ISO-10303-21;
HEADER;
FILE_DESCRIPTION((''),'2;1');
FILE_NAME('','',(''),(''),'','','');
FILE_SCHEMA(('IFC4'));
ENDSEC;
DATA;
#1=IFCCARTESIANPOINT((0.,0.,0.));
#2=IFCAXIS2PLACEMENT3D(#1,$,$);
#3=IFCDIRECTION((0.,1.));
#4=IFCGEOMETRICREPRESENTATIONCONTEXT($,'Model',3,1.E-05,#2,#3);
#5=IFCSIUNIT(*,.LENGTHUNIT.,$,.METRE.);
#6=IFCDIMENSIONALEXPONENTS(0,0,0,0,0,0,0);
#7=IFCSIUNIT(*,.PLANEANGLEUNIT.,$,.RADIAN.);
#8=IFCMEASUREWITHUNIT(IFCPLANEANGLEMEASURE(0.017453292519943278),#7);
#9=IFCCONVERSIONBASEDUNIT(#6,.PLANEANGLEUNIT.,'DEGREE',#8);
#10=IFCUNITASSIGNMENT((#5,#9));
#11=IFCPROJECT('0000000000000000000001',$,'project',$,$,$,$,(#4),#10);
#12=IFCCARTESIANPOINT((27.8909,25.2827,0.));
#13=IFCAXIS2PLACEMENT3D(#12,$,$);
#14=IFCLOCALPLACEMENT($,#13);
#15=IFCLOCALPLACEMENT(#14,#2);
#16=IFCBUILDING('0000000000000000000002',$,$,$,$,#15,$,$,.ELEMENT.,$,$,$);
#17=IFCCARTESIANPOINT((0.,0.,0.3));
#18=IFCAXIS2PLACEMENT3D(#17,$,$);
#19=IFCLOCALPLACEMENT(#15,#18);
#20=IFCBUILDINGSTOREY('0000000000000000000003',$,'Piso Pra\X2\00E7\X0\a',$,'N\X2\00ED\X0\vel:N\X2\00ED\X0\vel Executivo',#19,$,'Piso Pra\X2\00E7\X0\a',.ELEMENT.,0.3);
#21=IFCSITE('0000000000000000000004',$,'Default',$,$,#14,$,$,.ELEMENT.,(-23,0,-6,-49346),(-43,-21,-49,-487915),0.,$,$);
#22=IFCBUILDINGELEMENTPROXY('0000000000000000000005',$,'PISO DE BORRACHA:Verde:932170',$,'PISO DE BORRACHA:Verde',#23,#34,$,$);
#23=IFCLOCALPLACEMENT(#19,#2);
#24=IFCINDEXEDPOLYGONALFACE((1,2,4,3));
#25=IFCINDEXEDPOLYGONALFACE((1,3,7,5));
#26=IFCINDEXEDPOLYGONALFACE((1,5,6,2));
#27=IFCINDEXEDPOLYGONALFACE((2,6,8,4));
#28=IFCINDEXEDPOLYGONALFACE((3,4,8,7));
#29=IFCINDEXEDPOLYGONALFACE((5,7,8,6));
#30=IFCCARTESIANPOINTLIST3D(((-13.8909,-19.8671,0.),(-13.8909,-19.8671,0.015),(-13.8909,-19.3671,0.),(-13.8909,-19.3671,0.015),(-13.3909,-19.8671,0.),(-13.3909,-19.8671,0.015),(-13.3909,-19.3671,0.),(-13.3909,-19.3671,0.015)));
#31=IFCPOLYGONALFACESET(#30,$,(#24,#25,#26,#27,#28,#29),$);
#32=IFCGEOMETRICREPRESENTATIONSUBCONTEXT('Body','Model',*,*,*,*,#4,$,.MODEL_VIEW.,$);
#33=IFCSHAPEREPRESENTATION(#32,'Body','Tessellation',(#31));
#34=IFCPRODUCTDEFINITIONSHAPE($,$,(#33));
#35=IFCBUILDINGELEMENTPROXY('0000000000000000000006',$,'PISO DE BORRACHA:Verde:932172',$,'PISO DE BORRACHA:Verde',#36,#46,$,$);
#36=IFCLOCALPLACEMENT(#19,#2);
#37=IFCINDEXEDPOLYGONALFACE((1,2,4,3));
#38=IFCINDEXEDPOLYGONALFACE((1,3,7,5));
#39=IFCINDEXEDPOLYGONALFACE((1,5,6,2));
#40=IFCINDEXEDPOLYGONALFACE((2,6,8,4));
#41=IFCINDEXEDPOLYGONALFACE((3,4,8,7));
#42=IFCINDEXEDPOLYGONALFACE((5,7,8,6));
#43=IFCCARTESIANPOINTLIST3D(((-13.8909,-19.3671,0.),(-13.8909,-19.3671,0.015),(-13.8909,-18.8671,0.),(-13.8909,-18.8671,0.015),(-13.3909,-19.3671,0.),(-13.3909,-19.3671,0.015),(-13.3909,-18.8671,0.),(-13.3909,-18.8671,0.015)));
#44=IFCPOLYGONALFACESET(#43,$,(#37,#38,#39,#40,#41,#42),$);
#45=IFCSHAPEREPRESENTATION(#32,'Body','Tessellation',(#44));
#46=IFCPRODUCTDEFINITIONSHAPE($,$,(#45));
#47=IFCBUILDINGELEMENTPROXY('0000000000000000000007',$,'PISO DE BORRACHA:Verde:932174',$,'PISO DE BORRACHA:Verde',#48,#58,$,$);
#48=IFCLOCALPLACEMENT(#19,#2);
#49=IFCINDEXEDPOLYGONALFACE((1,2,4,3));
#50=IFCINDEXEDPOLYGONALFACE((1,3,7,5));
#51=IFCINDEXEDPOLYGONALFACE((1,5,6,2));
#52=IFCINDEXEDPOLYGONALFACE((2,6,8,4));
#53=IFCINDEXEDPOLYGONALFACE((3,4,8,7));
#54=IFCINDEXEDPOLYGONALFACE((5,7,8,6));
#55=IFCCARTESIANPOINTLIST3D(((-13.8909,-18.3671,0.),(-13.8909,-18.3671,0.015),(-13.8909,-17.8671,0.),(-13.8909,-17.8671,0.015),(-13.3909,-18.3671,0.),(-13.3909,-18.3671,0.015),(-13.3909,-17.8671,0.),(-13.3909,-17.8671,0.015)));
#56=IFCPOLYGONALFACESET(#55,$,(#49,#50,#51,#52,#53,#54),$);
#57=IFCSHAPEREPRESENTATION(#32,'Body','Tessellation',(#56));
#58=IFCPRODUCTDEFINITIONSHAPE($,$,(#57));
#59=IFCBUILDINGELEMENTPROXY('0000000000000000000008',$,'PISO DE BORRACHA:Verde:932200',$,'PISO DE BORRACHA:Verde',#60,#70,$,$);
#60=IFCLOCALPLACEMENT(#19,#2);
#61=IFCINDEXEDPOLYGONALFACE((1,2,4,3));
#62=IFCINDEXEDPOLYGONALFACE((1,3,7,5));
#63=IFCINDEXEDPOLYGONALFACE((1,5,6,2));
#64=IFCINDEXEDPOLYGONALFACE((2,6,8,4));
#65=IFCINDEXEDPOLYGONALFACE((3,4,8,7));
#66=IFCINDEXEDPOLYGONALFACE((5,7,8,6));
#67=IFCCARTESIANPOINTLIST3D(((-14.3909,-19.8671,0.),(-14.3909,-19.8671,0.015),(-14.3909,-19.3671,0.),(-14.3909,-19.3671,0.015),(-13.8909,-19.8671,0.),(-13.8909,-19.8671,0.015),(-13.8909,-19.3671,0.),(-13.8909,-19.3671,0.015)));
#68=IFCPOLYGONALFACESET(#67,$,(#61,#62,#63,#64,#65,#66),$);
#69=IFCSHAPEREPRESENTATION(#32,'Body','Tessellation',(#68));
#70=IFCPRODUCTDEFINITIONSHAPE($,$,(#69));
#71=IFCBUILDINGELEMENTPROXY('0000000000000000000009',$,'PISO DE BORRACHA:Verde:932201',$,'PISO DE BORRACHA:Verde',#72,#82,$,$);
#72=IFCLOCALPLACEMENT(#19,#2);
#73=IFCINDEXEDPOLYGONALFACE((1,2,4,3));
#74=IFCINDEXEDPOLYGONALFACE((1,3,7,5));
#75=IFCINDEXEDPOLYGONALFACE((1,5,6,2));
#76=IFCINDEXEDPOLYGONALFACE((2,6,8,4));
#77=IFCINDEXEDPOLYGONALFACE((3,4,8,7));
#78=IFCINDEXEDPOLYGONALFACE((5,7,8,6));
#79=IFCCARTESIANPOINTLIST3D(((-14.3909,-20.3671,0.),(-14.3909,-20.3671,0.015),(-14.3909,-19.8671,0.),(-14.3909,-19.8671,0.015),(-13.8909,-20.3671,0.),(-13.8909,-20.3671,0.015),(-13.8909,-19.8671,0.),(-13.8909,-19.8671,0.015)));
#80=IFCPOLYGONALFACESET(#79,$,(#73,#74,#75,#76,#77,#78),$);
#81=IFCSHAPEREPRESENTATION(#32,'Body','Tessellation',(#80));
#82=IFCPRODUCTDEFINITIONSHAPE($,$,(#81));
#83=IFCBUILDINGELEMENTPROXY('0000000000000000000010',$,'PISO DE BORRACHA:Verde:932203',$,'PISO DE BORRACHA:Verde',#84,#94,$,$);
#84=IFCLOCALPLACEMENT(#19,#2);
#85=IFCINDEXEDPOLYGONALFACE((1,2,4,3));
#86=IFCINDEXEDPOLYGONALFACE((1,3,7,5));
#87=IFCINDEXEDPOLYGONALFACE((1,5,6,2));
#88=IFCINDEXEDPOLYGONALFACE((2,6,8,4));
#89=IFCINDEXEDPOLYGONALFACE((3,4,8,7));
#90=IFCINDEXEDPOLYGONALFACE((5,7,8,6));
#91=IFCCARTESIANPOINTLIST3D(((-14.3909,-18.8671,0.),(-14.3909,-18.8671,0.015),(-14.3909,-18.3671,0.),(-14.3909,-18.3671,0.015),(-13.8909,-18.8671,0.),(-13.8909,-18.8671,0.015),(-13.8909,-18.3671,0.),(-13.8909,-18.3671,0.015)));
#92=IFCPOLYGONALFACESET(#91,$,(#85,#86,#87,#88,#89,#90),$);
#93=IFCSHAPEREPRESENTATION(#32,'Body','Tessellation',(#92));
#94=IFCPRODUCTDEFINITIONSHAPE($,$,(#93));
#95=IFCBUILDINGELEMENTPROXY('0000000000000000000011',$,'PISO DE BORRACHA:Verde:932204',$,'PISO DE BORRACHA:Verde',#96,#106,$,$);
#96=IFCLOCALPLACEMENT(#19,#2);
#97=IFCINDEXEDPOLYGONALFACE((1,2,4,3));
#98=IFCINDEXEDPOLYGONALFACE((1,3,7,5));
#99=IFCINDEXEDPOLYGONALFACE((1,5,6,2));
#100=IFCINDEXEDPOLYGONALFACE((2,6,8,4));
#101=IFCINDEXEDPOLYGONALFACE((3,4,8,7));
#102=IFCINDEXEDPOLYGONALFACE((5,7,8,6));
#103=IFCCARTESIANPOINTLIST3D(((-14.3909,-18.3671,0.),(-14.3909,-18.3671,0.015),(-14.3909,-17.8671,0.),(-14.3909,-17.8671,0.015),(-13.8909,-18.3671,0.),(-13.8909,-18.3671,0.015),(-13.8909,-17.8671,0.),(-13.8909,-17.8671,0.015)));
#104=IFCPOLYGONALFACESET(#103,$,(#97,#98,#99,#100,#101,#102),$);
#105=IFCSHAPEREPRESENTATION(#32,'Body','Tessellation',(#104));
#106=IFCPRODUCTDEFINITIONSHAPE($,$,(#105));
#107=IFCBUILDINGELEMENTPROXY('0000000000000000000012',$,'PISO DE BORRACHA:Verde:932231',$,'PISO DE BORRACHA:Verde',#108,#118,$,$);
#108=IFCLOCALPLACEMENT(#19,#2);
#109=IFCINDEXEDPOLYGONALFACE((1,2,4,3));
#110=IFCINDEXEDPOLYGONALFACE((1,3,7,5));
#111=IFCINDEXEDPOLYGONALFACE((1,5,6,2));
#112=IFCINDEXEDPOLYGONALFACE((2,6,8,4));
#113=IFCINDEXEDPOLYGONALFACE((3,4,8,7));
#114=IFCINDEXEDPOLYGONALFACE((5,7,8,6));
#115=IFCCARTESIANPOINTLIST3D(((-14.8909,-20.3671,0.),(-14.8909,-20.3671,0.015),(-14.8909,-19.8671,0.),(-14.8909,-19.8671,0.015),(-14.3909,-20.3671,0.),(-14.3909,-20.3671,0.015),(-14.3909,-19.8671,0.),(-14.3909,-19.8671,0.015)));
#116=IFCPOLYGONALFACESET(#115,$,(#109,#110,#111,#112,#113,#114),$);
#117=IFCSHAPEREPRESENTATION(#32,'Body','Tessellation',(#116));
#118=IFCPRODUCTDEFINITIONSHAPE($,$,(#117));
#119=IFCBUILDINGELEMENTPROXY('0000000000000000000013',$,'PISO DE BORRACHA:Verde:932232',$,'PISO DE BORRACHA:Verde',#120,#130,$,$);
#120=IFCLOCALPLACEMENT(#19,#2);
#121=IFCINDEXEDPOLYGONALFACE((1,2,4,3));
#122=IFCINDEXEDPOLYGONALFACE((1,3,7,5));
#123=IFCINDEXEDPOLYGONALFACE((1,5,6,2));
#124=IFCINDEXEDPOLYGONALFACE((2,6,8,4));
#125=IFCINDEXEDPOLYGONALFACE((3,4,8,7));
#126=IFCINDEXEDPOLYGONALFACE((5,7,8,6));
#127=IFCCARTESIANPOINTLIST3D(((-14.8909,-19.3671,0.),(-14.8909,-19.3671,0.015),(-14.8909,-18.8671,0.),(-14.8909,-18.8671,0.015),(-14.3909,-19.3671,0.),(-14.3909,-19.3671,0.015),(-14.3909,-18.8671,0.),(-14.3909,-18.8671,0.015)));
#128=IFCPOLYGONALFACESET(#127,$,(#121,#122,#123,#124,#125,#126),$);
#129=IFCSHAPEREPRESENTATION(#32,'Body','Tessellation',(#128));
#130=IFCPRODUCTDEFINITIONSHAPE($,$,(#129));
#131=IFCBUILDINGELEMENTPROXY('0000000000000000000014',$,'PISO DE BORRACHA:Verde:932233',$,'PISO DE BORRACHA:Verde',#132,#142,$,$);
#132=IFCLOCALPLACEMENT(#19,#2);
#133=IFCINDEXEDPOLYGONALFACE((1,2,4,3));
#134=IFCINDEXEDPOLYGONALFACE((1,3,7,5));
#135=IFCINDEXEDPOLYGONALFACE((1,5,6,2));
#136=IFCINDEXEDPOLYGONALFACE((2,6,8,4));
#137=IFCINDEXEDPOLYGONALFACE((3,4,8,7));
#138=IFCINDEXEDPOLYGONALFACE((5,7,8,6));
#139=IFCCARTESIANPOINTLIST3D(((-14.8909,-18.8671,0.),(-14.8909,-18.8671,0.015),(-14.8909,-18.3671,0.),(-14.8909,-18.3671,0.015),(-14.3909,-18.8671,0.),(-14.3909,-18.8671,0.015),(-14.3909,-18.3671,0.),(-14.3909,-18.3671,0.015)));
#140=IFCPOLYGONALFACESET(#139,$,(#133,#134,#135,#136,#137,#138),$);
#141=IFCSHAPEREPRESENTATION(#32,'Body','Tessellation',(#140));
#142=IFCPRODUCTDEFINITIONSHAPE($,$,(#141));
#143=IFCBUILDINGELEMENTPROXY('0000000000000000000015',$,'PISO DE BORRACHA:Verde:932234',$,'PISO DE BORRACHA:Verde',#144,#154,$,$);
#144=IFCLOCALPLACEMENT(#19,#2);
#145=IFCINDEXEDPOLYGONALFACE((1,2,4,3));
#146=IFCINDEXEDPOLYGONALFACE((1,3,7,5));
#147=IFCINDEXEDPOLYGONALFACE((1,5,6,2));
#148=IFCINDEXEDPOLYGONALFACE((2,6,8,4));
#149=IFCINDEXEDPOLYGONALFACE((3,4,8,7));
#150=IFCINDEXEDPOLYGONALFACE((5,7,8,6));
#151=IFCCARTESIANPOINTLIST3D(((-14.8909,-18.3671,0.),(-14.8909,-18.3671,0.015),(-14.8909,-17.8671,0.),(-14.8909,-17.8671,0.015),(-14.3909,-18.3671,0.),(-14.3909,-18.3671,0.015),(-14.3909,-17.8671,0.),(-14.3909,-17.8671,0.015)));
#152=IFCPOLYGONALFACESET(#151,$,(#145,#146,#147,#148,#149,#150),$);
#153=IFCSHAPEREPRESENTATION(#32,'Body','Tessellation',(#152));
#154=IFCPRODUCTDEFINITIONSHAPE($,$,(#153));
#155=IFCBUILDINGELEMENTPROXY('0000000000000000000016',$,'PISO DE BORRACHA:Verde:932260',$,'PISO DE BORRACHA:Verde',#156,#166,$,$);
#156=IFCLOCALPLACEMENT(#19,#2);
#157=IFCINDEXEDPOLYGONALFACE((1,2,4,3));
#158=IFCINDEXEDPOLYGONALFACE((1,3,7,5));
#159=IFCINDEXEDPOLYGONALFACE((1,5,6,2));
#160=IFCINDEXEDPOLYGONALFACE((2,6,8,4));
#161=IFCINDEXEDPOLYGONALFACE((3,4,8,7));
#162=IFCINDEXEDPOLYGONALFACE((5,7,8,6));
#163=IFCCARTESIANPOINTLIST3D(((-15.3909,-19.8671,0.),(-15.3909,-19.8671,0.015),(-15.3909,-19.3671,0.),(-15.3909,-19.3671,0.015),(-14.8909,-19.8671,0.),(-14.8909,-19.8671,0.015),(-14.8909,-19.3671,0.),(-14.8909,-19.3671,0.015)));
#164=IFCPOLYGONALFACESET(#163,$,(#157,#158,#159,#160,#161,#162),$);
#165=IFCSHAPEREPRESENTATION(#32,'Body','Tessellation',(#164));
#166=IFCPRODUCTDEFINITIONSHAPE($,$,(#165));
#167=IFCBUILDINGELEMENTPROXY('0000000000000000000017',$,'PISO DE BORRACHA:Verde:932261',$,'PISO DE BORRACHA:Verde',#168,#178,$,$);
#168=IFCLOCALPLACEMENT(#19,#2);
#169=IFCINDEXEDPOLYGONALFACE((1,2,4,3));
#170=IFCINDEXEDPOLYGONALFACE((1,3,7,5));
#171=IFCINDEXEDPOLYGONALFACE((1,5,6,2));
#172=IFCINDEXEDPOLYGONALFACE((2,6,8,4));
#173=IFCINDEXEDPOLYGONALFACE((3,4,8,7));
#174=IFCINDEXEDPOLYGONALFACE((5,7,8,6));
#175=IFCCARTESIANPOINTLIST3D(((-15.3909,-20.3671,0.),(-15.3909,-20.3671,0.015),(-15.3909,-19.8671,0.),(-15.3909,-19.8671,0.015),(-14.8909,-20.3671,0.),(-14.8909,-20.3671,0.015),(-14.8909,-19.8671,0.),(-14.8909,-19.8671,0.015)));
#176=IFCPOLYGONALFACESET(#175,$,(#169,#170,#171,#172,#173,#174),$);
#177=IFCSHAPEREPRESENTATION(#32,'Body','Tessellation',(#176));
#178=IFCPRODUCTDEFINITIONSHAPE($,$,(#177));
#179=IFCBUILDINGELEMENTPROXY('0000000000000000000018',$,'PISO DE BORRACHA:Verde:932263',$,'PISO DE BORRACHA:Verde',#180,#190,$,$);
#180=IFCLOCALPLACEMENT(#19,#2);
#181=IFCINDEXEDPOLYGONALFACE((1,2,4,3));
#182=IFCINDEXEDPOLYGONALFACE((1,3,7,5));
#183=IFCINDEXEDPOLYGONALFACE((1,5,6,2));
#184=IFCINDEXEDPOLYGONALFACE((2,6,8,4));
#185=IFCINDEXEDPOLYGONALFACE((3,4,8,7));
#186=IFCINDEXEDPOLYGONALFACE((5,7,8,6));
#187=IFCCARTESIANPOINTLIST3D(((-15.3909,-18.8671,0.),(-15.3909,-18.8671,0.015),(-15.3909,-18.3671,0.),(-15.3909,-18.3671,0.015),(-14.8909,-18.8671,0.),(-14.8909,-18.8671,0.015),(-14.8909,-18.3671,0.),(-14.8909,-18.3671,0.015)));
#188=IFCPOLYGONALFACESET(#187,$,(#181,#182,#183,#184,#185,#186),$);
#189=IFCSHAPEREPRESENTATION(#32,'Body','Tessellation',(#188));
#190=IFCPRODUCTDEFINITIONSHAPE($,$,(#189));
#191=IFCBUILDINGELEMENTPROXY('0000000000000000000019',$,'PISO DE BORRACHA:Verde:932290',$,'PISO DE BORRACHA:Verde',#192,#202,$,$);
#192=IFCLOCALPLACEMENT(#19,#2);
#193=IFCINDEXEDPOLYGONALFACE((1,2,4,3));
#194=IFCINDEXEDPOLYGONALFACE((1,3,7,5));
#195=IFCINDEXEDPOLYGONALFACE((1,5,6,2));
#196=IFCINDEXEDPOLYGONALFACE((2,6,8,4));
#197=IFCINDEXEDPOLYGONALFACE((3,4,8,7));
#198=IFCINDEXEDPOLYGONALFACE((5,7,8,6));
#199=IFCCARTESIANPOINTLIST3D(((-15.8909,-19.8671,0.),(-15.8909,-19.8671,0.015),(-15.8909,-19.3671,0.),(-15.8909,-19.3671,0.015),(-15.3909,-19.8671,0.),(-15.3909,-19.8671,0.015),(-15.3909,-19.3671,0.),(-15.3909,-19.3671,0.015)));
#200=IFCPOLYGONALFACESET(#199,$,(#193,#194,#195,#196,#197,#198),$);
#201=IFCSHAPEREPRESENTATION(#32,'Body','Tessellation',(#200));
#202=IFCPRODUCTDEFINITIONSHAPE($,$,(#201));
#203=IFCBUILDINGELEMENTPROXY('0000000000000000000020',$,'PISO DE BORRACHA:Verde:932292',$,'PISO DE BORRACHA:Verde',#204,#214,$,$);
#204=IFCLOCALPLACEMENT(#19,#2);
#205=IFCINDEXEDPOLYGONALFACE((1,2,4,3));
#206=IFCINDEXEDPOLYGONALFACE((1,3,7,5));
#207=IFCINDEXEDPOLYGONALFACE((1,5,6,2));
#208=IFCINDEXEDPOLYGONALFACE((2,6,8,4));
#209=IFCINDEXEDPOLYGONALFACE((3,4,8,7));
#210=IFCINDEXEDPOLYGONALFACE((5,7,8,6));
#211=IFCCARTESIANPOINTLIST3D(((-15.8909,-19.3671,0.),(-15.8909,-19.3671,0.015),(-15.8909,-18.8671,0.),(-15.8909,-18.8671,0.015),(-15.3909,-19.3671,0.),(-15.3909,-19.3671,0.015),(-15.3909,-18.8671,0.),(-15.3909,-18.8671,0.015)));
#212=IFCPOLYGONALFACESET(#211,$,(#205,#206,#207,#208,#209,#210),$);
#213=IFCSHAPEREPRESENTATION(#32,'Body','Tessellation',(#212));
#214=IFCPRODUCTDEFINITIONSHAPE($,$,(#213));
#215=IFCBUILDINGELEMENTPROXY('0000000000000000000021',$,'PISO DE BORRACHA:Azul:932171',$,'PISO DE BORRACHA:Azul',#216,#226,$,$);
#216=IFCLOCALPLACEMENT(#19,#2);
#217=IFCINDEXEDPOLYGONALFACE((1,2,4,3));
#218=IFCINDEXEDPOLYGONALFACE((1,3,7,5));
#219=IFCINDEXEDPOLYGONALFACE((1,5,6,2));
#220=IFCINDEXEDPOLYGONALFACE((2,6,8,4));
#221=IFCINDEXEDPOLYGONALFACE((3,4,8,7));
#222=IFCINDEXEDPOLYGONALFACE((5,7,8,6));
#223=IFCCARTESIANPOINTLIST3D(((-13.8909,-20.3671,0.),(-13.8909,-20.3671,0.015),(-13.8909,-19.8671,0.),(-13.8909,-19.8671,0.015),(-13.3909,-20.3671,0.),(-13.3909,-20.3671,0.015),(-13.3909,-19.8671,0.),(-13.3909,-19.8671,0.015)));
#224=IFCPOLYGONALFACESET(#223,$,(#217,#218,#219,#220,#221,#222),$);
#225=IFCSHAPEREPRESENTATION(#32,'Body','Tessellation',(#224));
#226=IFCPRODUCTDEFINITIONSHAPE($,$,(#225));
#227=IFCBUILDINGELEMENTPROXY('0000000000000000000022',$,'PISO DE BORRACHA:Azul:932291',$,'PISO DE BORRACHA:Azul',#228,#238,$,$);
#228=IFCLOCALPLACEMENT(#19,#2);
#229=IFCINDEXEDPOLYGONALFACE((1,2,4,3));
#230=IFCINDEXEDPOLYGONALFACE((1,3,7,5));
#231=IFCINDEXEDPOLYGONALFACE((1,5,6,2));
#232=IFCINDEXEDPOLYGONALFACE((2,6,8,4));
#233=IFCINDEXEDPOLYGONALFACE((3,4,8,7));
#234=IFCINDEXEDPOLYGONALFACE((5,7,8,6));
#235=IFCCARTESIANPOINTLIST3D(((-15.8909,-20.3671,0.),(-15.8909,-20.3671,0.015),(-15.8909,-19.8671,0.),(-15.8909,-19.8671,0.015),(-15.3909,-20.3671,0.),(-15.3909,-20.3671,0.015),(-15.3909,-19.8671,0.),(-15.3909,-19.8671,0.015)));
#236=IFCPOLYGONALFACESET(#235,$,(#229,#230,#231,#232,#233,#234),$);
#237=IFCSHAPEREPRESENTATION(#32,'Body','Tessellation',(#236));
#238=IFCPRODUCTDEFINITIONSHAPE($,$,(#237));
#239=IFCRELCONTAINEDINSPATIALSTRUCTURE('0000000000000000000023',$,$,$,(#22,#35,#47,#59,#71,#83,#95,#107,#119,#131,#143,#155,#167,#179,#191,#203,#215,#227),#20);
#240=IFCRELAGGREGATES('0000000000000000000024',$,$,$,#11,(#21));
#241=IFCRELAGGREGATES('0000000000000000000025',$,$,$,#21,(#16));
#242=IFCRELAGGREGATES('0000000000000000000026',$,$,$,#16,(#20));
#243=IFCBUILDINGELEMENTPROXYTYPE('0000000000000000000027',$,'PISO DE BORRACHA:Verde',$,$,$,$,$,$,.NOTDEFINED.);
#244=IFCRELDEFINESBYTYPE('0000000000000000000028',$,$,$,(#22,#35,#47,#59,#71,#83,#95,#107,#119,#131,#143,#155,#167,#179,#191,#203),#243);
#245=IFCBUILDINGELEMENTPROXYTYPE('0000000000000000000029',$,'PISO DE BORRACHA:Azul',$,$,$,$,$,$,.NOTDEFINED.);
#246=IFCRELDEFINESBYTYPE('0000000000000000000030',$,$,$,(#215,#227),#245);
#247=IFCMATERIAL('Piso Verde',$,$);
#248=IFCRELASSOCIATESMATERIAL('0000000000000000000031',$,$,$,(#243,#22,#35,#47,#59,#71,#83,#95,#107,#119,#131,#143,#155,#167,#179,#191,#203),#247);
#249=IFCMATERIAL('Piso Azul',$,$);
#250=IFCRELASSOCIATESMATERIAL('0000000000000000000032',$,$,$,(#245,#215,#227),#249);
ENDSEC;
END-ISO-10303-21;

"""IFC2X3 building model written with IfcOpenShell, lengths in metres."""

from ifc_helpers import new_model, entity, si_unit, converted_unit, direction, frame, origin, origin_2d_with_axis, place, context, subcontext, project, spatial, rectangle, extrude, source, transform, mapped, material, type_object, type_shapes, element, save


model = new_model("IFC2X3")

# Units and contexts
model_context = context("Model", 3, precision=1e-05, world=origin(), true_north=direction((0.0, 1.0)))
body_context = subcontext(model_context, "Body", "Model", "MODEL_VIEW")
ifc_project = project(units=[si_unit("LENGTHUNIT", "METRE"), converted_unit("PLANEANGLEUNIT", "DEGREE", entity("IfcPlaneAngleMeasure", 0.017453292519943278), si_unit("PLANEANGLEUNIT", "RADIAN"), dimensions=[0, 0, 0, 0, 0, 0, 0])], contexts=[model_context])

# Site, building, storey
site_placement = place(None, frame((27.8909, 25.2827, 0.0)))
site = spatial("IfcSite", under=ifc_project, at=site_placement, Name="Default", CompositionType="ELEMENT", RefLatitude=(-23, 0, -6, -49346), RefLongitude=(-43, -21, -49, -487915), RefElevation=0.0)
building_placement = place(site_placement, origin())
building = spatial("IfcBuilding", under=site, at=building_placement, CompositionType="ELEMENT")
storey_placement = place(building_placement, frame((0.0, 0.0, 0.3)))
storey = spatial("IfcBuildingStorey", under=building, at=storey_placement, Name="Piso Praça", ObjectType="Nível:Nível Executivo", LongName="Piso Praça", CompositionType="ELEMENT", Elevation=0.3)

# Building element proxies
ifc_material_1 = material(Name="Piso Verde")
building_element_proxy_type_1 = type_object("IfcBuildingElementProxyType", Name="PISO DE BORRACHA:Verde", PredefinedType="NOTDEFINED", material=ifc_material_1)
shared_shape_1 = source(origin(), body_context, "Body", "SweptSolid", [
    extrude(rectangle(XDim=0.5, YDim=0.5, at=origin_2d_with_axis()), frame((0.25, 0.25, 0.0), z_axis=(0.0, 0.0, 1.0), x_axis=(-1.0, 0.0, 0.0)), (0.0, 0.0, 1.0), 0.015),
])
type_shapes(building_element_proxy_type_1, [shared_shape_1])
for number, where, z_axis, x_axis, name in (
    (1, (-13.8909, -19.3671, 0.0), (0.0, 0.0, 1.0), (0.0, -1.0, 0.0), "PISO DE BORRACHA:Verde:932170"),
    (2, (-13.8909, -18.8671, 0.0), (0.0, 0.0, 1.0), (0.0, -1.0, 0.0), "PISO DE BORRACHA:Verde:932172"),
    (3, (-13.8909, -17.8671, 0.0), (0.0, 0.0, 1.0), (0.0, -1.0, 0.0), "PISO DE BORRACHA:Verde:932174"),
    (4, (-14.3909, -19.3671, 0.0), (0.0, 0.0, 1.0), (0.0, -1.0, 0.0), "PISO DE BORRACHA:Verde:932200"),
    (5, (-14.3909, -19.8671, 0.0), (0.0, 0.0, 1.0), (0.0, -1.0, 0.0), "PISO DE BORRACHA:Verde:932201"),
    (6, (-14.3909, -18.3671, 0.0), (0.0, 0.0, 1.0), (0.0, -1.0, 0.0), "PISO DE BORRACHA:Verde:932203"),
    (7, (-14.3909, -17.8671, 0.0), (0.0, 0.0, 1.0), (0.0, -1.0, 0.0), "PISO DE BORRACHA:Verde:932204"),
    (8, (-14.8909, -19.8671, 0.0), (0.0, 0.0, 1.0), (0.0, -1.0, 0.0), "PISO DE BORRACHA:Verde:932231"),
    (9, (-14.8909, -18.8671, 0.0), (0.0, 0.0, 1.0), (0.0, -1.0, 0.0), "PISO DE BORRACHA:Verde:932232"),
    (10, (-14.8909, -18.3671, 0.0), (0.0, 0.0, 1.0), (0.0, -1.0, 0.0), "PISO DE BORRACHA:Verde:932233"),
    (11, (-14.8909, -17.8671, 0.0), (0.0, 0.0, 1.0), (0.0, -1.0, 0.0), "PISO DE BORRACHA:Verde:932234"),
    (12, (-15.3909, -19.3671, 0.0), (0.0, 0.0, 1.0), (0.0, -1.0, 0.0), "PISO DE BORRACHA:Verde:932260"),
    (13, (-15.3909, -19.8671, 0.0), (0.0, 0.0, 1.0), (0.0, -1.0, 0.0), "PISO DE BORRACHA:Verde:932261"),
    (14, (-15.3909, -18.3671, 0.0), (0.0, 0.0, 1.0), (0.0, -1.0, 0.0), "PISO DE BORRACHA:Verde:932263"),
    (15, (-15.8909, -19.3671, 0.0), (0.0, 0.0, 1.0), (0.0, -1.0, 0.0), "PISO DE BORRACHA:Verde:932290"),
    (16, (-15.8909, -18.8671, 0.0), (0.0, 0.0, 1.0), (0.0, -1.0, 0.0), "PISO DE BORRACHA:Verde:932292"),
):
    element("IfcBuildingElementProxy", number, at=place(storey_placement, frame(where, z_axis=z_axis, x_axis=x_axis)), inside=storey, type_object=building_element_proxy_type_1, material=ifc_material_1, Name=name, ObjectType="PISO DE BORRACHA:Verde", context=body_context, shape_type="MappedRepresentation", body=[
        mapped(shared_shape_1, transform((0.0, 0.0, 0.0), scale=1.0)),
    ])
ifc_material_2 = material(Name="Piso Azul")
building_element_proxy_type_2 = type_object("IfcBuildingElementProxyType", Name="PISO DE BORRACHA:Azul", PredefinedType="NOTDEFINED", material=ifc_material_2)
shared_shape_2 = source(origin(), body_context, "Body", "SweptSolid", [
    extrude(rectangle(XDim=0.5, YDim=0.5, at=origin_2d_with_axis()), frame((0.25, 0.25, 0.0), z_axis=(0.0, 0.0, 1.0), x_axis=(-1.0, 0.0, 0.0)), (0.0, 0.0, 1.0), 0.015),
])
type_shapes(building_element_proxy_type_2, [shared_shape_2])
for number, where, z_axis, x_axis, name in (
    (17, (-13.8909, -19.8671, 0.0), (0.0, 0.0, 1.0), (0.0, -1.0, 0.0), "PISO DE BORRACHA:Azul:932171"),
    (18, (-15.8909, -19.8671, 0.0), (0.0, 0.0, 1.0), (0.0, -1.0, 0.0), "PISO DE BORRACHA:Azul:932291"),
):
    element("IfcBuildingElementProxy", number, at=place(storey_placement, frame(where, z_axis=z_axis, x_axis=x_axis)), inside=storey, type_object=building_element_proxy_type_2, material=ifc_material_2, Name=name, ObjectType="PISO DE BORRACHA:Azul", context=body_context, shape_type="MappedRepresentation", body=[
        mapped(shared_shape_2, transform((0.0, 0.0, 0.0), scale=1.0)),
    ])

save(model, "model.ifc")
